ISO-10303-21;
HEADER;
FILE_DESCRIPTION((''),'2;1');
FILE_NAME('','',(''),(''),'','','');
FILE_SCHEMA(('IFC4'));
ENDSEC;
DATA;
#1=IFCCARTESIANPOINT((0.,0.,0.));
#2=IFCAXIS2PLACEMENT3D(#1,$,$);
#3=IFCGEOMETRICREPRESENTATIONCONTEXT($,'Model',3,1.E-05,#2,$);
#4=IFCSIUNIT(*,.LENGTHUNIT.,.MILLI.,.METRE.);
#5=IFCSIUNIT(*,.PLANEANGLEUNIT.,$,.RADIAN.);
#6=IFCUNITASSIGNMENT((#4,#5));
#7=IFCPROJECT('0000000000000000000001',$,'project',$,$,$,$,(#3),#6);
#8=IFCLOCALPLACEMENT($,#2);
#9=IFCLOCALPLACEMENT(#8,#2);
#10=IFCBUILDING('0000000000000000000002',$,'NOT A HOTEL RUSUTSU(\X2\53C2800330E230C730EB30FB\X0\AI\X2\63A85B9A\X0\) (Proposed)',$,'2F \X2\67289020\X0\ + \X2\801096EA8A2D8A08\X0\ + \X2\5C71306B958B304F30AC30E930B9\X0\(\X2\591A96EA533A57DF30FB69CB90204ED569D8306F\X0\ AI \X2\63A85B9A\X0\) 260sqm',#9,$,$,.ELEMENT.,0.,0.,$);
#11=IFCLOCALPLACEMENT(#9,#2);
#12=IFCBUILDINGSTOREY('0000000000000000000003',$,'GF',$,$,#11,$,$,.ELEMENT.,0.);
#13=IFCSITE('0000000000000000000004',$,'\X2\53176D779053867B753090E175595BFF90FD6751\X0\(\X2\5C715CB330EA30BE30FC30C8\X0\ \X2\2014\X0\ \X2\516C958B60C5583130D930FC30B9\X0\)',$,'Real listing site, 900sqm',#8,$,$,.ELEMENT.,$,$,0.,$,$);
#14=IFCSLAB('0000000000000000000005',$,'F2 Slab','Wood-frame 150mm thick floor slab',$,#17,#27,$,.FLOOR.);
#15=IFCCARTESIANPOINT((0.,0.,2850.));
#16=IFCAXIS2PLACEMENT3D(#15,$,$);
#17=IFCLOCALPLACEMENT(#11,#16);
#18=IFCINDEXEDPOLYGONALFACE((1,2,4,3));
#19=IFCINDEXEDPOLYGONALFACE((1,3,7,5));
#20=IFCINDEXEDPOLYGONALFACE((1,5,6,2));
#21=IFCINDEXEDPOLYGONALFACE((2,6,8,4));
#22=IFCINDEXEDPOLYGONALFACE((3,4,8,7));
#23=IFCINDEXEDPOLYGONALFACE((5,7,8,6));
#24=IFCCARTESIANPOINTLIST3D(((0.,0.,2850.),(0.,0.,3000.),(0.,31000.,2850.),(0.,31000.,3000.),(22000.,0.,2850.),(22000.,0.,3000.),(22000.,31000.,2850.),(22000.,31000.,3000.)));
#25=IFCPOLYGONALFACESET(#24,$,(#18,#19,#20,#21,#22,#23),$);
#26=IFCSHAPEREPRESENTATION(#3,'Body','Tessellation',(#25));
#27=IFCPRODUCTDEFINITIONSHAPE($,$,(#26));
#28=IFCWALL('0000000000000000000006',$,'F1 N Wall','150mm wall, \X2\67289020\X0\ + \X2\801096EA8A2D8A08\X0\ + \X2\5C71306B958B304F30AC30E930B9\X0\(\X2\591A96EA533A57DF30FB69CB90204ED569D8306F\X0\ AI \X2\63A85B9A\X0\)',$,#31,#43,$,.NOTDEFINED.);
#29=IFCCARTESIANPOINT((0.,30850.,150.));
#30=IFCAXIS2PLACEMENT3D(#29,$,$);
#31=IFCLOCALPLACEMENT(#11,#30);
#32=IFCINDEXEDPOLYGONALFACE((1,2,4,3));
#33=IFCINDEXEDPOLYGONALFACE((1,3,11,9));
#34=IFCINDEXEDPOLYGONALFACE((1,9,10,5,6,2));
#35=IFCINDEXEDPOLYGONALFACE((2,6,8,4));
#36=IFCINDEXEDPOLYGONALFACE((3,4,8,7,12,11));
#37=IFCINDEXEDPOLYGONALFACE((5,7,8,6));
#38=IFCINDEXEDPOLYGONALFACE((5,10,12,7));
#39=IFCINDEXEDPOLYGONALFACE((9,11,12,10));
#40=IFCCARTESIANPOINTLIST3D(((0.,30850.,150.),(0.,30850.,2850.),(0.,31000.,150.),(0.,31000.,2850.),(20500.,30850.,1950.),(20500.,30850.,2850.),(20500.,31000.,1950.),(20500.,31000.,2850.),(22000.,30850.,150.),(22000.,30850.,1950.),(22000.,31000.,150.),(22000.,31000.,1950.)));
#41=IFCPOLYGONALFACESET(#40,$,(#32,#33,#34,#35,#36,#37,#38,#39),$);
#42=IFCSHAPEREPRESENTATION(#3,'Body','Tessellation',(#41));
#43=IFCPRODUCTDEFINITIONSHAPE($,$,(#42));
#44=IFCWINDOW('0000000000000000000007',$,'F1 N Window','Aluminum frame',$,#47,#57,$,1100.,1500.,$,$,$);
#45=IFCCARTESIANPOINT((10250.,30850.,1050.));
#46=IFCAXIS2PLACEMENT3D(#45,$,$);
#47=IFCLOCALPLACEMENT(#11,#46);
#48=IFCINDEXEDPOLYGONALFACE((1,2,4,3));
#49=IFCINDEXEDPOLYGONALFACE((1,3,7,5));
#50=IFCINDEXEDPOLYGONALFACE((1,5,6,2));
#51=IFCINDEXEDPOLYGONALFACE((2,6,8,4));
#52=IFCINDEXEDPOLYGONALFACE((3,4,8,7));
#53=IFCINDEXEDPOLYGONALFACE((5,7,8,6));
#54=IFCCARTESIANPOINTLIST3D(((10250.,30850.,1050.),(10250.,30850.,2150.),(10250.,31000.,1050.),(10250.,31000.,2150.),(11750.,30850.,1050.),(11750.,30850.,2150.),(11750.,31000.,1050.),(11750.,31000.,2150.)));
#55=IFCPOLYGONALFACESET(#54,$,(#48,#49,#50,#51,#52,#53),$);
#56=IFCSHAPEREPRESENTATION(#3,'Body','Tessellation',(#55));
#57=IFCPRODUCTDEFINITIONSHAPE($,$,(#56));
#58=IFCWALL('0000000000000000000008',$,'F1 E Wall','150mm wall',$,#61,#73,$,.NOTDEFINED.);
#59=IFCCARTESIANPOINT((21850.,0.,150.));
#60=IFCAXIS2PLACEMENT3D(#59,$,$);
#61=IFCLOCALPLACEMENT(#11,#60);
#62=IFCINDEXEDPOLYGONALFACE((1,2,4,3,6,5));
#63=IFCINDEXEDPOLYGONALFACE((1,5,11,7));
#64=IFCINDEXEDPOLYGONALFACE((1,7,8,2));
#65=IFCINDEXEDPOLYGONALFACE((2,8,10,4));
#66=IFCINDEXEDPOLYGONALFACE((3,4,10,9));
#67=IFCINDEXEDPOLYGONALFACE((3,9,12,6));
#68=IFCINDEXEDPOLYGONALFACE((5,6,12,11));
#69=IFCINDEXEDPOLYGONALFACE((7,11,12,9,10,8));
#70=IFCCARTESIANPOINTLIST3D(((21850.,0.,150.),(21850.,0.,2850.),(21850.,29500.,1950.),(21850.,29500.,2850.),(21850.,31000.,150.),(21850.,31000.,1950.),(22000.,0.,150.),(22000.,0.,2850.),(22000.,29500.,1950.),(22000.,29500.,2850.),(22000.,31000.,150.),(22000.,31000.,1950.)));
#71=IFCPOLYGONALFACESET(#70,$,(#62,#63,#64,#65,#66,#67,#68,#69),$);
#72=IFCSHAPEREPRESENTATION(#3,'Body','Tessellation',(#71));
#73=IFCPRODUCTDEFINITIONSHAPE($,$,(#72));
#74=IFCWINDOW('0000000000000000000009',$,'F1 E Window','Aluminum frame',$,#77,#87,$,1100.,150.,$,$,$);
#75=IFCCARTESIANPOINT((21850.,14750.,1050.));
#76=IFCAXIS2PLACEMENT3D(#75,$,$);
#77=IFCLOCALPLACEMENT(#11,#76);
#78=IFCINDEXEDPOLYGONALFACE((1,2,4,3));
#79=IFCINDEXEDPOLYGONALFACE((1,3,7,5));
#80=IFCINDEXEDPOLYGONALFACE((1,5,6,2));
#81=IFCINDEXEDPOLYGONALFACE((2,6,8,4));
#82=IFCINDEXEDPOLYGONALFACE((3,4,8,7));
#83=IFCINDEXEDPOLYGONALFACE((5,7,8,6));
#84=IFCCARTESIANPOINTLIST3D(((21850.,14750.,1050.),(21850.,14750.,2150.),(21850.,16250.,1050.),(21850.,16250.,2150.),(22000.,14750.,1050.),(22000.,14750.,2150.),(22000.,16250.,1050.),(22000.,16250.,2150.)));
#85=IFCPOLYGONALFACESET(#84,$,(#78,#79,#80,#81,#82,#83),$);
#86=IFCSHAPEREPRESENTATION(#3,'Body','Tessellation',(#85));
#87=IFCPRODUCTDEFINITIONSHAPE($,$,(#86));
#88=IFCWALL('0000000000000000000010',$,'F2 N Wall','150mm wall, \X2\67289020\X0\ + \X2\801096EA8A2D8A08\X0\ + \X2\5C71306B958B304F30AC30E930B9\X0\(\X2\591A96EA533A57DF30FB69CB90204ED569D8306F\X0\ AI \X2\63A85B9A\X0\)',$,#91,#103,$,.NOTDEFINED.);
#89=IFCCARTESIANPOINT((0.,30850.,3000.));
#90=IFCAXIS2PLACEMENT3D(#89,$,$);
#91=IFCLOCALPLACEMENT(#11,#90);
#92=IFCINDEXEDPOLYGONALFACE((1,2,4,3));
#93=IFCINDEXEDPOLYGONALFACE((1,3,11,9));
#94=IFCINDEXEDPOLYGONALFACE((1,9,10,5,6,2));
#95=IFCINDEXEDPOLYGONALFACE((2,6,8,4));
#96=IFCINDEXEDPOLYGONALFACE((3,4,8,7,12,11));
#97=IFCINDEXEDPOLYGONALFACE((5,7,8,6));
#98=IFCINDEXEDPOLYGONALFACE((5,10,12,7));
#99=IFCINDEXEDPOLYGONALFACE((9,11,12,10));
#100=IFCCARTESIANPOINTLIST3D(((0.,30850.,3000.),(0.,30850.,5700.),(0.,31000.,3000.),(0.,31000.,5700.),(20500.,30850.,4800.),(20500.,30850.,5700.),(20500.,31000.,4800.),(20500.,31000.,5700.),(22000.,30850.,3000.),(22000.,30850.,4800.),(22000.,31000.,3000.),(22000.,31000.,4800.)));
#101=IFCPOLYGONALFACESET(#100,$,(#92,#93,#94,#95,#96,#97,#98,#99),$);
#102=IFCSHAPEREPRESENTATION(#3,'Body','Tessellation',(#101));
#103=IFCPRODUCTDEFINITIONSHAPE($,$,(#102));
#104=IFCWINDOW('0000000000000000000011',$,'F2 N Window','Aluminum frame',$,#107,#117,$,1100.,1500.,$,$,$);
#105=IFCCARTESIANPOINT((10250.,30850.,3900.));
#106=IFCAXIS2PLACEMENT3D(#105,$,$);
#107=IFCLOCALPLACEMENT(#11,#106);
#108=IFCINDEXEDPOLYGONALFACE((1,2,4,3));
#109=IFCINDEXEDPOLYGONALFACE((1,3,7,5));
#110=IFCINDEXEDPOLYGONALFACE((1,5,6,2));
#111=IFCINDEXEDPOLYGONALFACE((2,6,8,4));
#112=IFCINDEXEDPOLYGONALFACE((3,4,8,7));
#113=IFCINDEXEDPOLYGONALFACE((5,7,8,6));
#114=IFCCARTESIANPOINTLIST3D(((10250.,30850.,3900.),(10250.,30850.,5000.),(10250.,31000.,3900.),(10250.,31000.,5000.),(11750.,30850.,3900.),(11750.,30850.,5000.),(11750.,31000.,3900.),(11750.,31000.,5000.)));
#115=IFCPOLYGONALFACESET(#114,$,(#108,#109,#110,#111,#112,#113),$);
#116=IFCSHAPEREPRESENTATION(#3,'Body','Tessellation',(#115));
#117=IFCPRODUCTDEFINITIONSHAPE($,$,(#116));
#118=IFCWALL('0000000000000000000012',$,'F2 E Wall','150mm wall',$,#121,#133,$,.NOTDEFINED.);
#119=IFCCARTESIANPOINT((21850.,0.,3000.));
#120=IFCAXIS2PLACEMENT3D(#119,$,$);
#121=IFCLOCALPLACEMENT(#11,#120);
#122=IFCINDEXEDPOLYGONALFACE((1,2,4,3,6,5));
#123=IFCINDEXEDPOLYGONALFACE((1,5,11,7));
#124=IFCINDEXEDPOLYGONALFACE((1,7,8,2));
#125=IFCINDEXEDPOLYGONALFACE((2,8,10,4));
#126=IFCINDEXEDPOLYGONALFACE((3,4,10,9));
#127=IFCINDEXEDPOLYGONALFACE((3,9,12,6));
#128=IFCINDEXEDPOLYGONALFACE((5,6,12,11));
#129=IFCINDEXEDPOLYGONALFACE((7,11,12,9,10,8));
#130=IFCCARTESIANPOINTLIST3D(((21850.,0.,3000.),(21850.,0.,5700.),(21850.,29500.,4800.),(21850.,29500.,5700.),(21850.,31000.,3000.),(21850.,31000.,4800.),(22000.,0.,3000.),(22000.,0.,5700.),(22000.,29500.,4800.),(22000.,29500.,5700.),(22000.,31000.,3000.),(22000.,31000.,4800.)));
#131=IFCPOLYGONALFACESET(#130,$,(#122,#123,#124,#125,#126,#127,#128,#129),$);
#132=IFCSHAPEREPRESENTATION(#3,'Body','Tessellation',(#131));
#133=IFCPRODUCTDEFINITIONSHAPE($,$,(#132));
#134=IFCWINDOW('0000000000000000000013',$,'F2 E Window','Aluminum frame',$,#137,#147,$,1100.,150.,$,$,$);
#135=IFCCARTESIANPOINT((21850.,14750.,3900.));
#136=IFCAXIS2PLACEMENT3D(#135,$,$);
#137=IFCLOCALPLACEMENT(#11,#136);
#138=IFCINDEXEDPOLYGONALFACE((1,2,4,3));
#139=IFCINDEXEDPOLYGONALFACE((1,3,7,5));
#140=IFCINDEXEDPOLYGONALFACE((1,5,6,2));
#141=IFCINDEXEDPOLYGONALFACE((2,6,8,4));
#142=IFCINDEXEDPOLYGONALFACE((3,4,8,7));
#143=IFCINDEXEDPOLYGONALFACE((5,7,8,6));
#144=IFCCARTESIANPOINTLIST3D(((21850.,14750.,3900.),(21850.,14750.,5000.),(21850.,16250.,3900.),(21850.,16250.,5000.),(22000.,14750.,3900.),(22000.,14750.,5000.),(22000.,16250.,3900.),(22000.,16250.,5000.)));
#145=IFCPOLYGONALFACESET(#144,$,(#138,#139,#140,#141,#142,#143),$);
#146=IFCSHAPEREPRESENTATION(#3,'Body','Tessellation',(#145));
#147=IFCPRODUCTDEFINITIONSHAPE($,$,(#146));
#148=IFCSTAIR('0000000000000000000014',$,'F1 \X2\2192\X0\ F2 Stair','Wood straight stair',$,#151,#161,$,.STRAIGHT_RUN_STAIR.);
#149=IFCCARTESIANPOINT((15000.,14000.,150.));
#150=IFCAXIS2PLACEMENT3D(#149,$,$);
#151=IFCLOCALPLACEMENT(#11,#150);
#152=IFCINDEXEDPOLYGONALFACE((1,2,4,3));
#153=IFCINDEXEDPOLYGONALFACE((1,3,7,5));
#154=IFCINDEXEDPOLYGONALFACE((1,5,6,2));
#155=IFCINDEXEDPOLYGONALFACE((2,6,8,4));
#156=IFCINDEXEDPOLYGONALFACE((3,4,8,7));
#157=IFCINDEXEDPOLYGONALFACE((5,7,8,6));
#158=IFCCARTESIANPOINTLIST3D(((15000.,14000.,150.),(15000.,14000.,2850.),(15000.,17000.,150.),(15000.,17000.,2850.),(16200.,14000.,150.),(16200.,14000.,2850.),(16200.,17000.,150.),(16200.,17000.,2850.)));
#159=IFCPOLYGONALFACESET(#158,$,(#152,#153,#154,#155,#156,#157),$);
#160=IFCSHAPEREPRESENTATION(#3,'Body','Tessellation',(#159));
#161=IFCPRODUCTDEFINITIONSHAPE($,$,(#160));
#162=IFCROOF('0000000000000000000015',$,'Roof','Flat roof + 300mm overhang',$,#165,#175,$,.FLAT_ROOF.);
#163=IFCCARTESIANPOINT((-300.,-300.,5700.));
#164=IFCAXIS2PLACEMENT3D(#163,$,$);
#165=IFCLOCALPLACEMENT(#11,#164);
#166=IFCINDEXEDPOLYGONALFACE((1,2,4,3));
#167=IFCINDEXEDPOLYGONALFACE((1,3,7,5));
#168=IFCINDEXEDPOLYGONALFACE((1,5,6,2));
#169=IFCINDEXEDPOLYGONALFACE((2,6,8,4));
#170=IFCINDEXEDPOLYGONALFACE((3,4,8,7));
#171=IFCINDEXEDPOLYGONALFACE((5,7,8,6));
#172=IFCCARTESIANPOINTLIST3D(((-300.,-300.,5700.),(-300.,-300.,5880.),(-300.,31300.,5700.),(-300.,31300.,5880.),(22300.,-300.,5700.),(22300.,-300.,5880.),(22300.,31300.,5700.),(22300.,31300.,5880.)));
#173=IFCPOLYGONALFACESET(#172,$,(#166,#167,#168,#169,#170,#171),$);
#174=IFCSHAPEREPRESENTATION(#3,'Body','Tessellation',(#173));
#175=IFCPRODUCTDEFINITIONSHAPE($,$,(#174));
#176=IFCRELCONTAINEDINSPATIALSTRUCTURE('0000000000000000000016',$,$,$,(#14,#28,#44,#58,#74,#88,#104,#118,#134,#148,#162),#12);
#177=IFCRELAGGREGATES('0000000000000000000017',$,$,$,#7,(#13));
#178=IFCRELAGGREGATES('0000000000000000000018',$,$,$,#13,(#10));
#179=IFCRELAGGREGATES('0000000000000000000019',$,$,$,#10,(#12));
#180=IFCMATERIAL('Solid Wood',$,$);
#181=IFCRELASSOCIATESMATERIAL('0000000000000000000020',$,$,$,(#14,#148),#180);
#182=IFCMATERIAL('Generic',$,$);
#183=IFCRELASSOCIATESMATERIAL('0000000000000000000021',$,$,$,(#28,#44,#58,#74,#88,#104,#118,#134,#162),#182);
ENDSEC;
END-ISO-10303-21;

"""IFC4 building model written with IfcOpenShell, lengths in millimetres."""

from ifc_helpers import new_model, si_unit, frame, frame_2d, origin, place, context, project, spatial, rectangle, extrude, material, element, fill, save


model = new_model("IFC4")

# Units and contexts
model_context = context("Model", 3, precision=1e-05, world=origin())
ifc_project = project(units=[si_unit("LENGTHUNIT", "METRE", prefix="MILLI"), si_unit("PLANEANGLEUNIT", "RADIAN")], contexts=[model_context])

# Site, building, storey
site_placement = place(None, origin())
site = spatial("IfcSite", under=ifc_project, at=site_placement, Name="北海道虻田郡留寿都村(山岳リゾート — 公開情報ベース)", ObjectType="Real listing site, 900sqm", CompositionType="ELEMENT", RefElevation=0.0)
building_placement = place(site_placement, origin())
building = spatial("IfcBuilding", under=site, at=building_placement, Name="NOT A HOTEL RUSUTSU(参考モデル・AI推定) (Proposed)", ObjectType="2F 木造 + 耐雪設計 + 山に開くガラス(多雪区域・構造仕様は AI 推定) 260sqm", CompositionType="ELEMENT", ElevationOfRefHeight=0.0, ElevationOfTerrain=0.0)
storey_placement = place(building_placement, origin())
storey = spatial("IfcBuildingStorey", under=building, at=storey_placement, Name="GF", CompositionType="ELEMENT", Elevation=0.0)

# Slab
ifc_material_1 = material(Name="Solid Wood")
slab_1_placement = place(storey_placement, frame((0.0, 0.0, 2850.0)))
element("IfcSlab", 1, at=slab_1_placement, inside=storey, material=ifc_material_1, Name="F2 Slab", Description="Wood-frame 150mm thick floor slab", PredefinedType="FLOOR", context=model_context, shape_type="SweptSolid", body=[
    extrude(rectangle(XDim=22000.0, YDim=31000.0, at=frame_2d((11000.0, 15500.0))), frame((0.0, 0.0, 2850.0)), (0.0, 0.0, 1.0), 150.0),
])

# Wall, opening, window
ifc_material_2 = material(Name="Generic")
wall_1_placement = place(storey_placement, frame((0.0, 30850.0, 150.0)))
wall_1 = element("IfcWall", 2, at=wall_1_placement, inside=storey, material=ifc_material_2, Name="F1 N Wall", Description="150mm wall, 木造 + 耐雪設計 + 山に開くガラス(多雪区域・構造仕様は AI 推定)", PredefinedType="NOTDEFINED", context=model_context, shape_type="SweptSolid", body=[
    extrude(rectangle(XDim=22000.0, YDim=150.0, at=frame_2d((11000.0, 75.0))), frame((0.0, 30850.0, 150.0)), (0.0, 0.0, 1.0), 2700.0),
])
opening_1_placement = place(storey_placement, frame((10250.0, 30850.0, 1050.0)))
opening_1 = element("IfcOpeningElement", 3, at=opening_1_placement, cuts=wall_1, PredefinedType="NOTDEFINED", context=model_context, shape_type="SweptSolid", body=[
    extrude(rectangle(XDim=1500.0, YDim=150.0, at=frame_2d((750.0, 75.0))), frame((10250.0, 30850.0, 1050.0)), (0.0, 0.0, 1.0), 1100.0),
])
window_1_placement = place(storey_placement, frame((10250.0, 30850.0, 1050.0)))
window_1 = element("IfcWindow", 4, at=window_1_placement, inside=storey, material=ifc_material_2, Name="F1 N Window", Description="Aluminum frame", OverallHeight=1100.0, OverallWidth=1500.0, context=model_context, shape_type="SweptSolid", body=[
    extrude(rectangle(XDim=1500.0, YDim=150.0, at=frame_2d((750.0, 75.0))), frame((10250.0, 30850.0, 1050.0)), (0.0, 0.0, 1.0), 1100.0),
])
fill(opening_1, window_1)

# Walls, openings, windows
wall_2_placement = place(storey_placement, frame((21850.0, 0.0, 150.0)))
wall_2 = element("IfcWall", 5, at=wall_2_placement, inside=storey, material=ifc_material_2, Name="F1 E Wall", Description="150mm wall", PredefinedType="NOTDEFINED", context=model_context, shape_type="SweptSolid", body=[
    extrude(rectangle(XDim=150.0, YDim=31000.0, at=frame_2d((75.0, 15500.0))), frame((21850.0, 0.0, 150.0)), (0.0, 0.0, 1.0), 2700.0),
])
opening_2_placement = place(storey_placement, frame((21850.0, 14750.0, 1050.0)))
opening_2 = element("IfcOpeningElement", 6, at=opening_2_placement, cuts=wall_2, PredefinedType="NOTDEFINED", context=model_context, shape_type="SweptSolid", body=[
    extrude(rectangle(XDim=150.0, YDim=1500.0, at=frame_2d((75.0, 750.0))), frame((21850.0, 14750.0, 1050.0)), (0.0, 0.0, 1.0), 1100.0),
])
window_2_placement = place(storey_placement, frame((21850.0, 14750.0, 1050.0)))
window_2 = element("IfcWindow", 7, at=window_2_placement, inside=storey, material=ifc_material_2, Name="F1 E Window", Description="Aluminum frame", OverallHeight=1100.0, OverallWidth=150.0, context=model_context, shape_type="SweptSolid", body=[
    extrude(rectangle(XDim=150.0, YDim=1500.0, at=frame_2d((75.0, 750.0))), frame((21850.0, 14750.0, 1050.0)), (0.0, 0.0, 1.0), 1100.0),
])
fill(opening_2, window_2)
wall_3_placement = place(storey_placement, frame((0.0, 30850.0, 3000.0)))
wall_3 = element("IfcWall", 8, at=wall_3_placement, inside=storey, material=ifc_material_2, Name="F2 N Wall", Description="150mm wall, 木造 + 耐雪設計 + 山に開くガラス(多雪区域・構造仕様は AI 推定)", PredefinedType="NOTDEFINED", context=model_context, shape_type="SweptSolid", body=[
    extrude(rectangle(XDim=22000.0, YDim=150.0, at=frame_2d((11000.0, 75.0))), frame((0.0, 30850.0, 3000.0)), (0.0, 0.0, 1.0), 2700.0),
])
opening_3_placement = place(storey_placement, frame((10250.0, 30850.0, 3900.0)))
opening_3 = element("IfcOpeningElement", 9, at=opening_3_placement, cuts=wall_3, PredefinedType="NOTDEFINED", context=model_context, shape_type="SweptSolid", body=[
    extrude(rectangle(XDim=1500.0, YDim=150.0, at=frame_2d((750.0, 75.0))), frame((10250.0, 30850.0, 3900.0)), (0.0, 0.0, 1.0), 1100.0),
])
window_3_placement = place(storey_placement, frame((10250.0, 30850.0, 3900.0)))
window_3 = element("IfcWindow", 10, at=window_3_placement, inside=storey, material=ifc_material_2, Name="F2 N Window", Description="Aluminum frame", OverallHeight=1100.0, OverallWidth=1500.0, context=model_context, shape_type="SweptSolid", body=[
    extrude(rectangle(XDim=1500.0, YDim=150.0, at=frame_2d((750.0, 75.0))), frame((10250.0, 30850.0, 3900.0)), (0.0, 0.0, 1.0), 1100.0),
])
fill(opening_3, window_3)
wall_4_placement = place(storey_placement, frame((21850.0, 0.0, 3000.0)))
wall_4 = element("IfcWall", 11, at=wall_4_placement, inside=storey, material=ifc_material_2, Name="F2 E Wall", Description="150mm wall", PredefinedType="NOTDEFINED", context=model_context, shape_type="SweptSolid", body=[
    extrude(rectangle(XDim=150.0, YDim=31000.0, at=frame_2d((75.0, 15500.0))), frame((21850.0, 0.0, 3000.0)), (0.0, 0.0, 1.0), 2700.0),
])
opening_4_placement = place(storey_placement, frame((21850.0, 14750.0, 3900.0)))
opening_4 = element("IfcOpeningElement", 12, at=opening_4_placement, cuts=wall_4, PredefinedType="NOTDEFINED", context=model_context, shape_type="SweptSolid", body=[
    extrude(rectangle(XDim=150.0, YDim=1500.0, at=frame_2d((75.0, 750.0))), frame((21850.0, 14750.0, 3900.0)), (0.0, 0.0, 1.0), 1100.0),
])
window_4_placement = place(storey_placement, frame((21850.0, 14750.0, 3900.0)))
window_4 = element("IfcWindow", 13, at=window_4_placement, inside=storey, material=ifc_material_2, Name="F2 E Window", Description="Aluminum frame", OverallHeight=1100.0, OverallWidth=150.0, context=model_context, shape_type="SweptSolid", body=[
    extrude(rectangle(XDim=150.0, YDim=1500.0, at=frame_2d((75.0, 750.0))), frame((21850.0, 14750.0, 3900.0)), (0.0, 0.0, 1.0), 1100.0),
])
fill(opening_4, window_4)

# Stair
stair_placement = place(storey_placement, frame((15000.0, 14000.0, 150.0)))
element("IfcStair", 14, at=stair_placement, inside=storey, material=ifc_material_1, Name="F1 → F2 Stair", Description="Wood straight stair", PredefinedType="STRAIGHT_RUN_STAIR", context=model_context, shape_type="SweptSolid", body=[
    extrude(rectangle(XDim=1200.0, YDim=3000.0, at=frame_2d((600.0, 1500.0))), frame((15000.0, 14000.0, 150.0)), (0.0, 0.0, 1.0), 2700.0),
])

# Roof
roof_placement = place(storey_placement, frame((-300.0, -300.0, 5700.0)))
element("IfcRoof", 15, at=roof_placement, inside=storey, material=ifc_material_2, Name="Roof", Description="Flat roof + 300mm overhang", PredefinedType="FLAT_ROOF", context=model_context, shape_type="SweptSolid", body=[
    extrude(rectangle(XDim=22600.0, YDim=31600.0, at=frame_2d((11300.0, 15800.0))), frame((-300.0, -300.0, 5700.0)), (0.0, 0.0, 1.0), 180.0),
])

save(model, "model.ifc")
